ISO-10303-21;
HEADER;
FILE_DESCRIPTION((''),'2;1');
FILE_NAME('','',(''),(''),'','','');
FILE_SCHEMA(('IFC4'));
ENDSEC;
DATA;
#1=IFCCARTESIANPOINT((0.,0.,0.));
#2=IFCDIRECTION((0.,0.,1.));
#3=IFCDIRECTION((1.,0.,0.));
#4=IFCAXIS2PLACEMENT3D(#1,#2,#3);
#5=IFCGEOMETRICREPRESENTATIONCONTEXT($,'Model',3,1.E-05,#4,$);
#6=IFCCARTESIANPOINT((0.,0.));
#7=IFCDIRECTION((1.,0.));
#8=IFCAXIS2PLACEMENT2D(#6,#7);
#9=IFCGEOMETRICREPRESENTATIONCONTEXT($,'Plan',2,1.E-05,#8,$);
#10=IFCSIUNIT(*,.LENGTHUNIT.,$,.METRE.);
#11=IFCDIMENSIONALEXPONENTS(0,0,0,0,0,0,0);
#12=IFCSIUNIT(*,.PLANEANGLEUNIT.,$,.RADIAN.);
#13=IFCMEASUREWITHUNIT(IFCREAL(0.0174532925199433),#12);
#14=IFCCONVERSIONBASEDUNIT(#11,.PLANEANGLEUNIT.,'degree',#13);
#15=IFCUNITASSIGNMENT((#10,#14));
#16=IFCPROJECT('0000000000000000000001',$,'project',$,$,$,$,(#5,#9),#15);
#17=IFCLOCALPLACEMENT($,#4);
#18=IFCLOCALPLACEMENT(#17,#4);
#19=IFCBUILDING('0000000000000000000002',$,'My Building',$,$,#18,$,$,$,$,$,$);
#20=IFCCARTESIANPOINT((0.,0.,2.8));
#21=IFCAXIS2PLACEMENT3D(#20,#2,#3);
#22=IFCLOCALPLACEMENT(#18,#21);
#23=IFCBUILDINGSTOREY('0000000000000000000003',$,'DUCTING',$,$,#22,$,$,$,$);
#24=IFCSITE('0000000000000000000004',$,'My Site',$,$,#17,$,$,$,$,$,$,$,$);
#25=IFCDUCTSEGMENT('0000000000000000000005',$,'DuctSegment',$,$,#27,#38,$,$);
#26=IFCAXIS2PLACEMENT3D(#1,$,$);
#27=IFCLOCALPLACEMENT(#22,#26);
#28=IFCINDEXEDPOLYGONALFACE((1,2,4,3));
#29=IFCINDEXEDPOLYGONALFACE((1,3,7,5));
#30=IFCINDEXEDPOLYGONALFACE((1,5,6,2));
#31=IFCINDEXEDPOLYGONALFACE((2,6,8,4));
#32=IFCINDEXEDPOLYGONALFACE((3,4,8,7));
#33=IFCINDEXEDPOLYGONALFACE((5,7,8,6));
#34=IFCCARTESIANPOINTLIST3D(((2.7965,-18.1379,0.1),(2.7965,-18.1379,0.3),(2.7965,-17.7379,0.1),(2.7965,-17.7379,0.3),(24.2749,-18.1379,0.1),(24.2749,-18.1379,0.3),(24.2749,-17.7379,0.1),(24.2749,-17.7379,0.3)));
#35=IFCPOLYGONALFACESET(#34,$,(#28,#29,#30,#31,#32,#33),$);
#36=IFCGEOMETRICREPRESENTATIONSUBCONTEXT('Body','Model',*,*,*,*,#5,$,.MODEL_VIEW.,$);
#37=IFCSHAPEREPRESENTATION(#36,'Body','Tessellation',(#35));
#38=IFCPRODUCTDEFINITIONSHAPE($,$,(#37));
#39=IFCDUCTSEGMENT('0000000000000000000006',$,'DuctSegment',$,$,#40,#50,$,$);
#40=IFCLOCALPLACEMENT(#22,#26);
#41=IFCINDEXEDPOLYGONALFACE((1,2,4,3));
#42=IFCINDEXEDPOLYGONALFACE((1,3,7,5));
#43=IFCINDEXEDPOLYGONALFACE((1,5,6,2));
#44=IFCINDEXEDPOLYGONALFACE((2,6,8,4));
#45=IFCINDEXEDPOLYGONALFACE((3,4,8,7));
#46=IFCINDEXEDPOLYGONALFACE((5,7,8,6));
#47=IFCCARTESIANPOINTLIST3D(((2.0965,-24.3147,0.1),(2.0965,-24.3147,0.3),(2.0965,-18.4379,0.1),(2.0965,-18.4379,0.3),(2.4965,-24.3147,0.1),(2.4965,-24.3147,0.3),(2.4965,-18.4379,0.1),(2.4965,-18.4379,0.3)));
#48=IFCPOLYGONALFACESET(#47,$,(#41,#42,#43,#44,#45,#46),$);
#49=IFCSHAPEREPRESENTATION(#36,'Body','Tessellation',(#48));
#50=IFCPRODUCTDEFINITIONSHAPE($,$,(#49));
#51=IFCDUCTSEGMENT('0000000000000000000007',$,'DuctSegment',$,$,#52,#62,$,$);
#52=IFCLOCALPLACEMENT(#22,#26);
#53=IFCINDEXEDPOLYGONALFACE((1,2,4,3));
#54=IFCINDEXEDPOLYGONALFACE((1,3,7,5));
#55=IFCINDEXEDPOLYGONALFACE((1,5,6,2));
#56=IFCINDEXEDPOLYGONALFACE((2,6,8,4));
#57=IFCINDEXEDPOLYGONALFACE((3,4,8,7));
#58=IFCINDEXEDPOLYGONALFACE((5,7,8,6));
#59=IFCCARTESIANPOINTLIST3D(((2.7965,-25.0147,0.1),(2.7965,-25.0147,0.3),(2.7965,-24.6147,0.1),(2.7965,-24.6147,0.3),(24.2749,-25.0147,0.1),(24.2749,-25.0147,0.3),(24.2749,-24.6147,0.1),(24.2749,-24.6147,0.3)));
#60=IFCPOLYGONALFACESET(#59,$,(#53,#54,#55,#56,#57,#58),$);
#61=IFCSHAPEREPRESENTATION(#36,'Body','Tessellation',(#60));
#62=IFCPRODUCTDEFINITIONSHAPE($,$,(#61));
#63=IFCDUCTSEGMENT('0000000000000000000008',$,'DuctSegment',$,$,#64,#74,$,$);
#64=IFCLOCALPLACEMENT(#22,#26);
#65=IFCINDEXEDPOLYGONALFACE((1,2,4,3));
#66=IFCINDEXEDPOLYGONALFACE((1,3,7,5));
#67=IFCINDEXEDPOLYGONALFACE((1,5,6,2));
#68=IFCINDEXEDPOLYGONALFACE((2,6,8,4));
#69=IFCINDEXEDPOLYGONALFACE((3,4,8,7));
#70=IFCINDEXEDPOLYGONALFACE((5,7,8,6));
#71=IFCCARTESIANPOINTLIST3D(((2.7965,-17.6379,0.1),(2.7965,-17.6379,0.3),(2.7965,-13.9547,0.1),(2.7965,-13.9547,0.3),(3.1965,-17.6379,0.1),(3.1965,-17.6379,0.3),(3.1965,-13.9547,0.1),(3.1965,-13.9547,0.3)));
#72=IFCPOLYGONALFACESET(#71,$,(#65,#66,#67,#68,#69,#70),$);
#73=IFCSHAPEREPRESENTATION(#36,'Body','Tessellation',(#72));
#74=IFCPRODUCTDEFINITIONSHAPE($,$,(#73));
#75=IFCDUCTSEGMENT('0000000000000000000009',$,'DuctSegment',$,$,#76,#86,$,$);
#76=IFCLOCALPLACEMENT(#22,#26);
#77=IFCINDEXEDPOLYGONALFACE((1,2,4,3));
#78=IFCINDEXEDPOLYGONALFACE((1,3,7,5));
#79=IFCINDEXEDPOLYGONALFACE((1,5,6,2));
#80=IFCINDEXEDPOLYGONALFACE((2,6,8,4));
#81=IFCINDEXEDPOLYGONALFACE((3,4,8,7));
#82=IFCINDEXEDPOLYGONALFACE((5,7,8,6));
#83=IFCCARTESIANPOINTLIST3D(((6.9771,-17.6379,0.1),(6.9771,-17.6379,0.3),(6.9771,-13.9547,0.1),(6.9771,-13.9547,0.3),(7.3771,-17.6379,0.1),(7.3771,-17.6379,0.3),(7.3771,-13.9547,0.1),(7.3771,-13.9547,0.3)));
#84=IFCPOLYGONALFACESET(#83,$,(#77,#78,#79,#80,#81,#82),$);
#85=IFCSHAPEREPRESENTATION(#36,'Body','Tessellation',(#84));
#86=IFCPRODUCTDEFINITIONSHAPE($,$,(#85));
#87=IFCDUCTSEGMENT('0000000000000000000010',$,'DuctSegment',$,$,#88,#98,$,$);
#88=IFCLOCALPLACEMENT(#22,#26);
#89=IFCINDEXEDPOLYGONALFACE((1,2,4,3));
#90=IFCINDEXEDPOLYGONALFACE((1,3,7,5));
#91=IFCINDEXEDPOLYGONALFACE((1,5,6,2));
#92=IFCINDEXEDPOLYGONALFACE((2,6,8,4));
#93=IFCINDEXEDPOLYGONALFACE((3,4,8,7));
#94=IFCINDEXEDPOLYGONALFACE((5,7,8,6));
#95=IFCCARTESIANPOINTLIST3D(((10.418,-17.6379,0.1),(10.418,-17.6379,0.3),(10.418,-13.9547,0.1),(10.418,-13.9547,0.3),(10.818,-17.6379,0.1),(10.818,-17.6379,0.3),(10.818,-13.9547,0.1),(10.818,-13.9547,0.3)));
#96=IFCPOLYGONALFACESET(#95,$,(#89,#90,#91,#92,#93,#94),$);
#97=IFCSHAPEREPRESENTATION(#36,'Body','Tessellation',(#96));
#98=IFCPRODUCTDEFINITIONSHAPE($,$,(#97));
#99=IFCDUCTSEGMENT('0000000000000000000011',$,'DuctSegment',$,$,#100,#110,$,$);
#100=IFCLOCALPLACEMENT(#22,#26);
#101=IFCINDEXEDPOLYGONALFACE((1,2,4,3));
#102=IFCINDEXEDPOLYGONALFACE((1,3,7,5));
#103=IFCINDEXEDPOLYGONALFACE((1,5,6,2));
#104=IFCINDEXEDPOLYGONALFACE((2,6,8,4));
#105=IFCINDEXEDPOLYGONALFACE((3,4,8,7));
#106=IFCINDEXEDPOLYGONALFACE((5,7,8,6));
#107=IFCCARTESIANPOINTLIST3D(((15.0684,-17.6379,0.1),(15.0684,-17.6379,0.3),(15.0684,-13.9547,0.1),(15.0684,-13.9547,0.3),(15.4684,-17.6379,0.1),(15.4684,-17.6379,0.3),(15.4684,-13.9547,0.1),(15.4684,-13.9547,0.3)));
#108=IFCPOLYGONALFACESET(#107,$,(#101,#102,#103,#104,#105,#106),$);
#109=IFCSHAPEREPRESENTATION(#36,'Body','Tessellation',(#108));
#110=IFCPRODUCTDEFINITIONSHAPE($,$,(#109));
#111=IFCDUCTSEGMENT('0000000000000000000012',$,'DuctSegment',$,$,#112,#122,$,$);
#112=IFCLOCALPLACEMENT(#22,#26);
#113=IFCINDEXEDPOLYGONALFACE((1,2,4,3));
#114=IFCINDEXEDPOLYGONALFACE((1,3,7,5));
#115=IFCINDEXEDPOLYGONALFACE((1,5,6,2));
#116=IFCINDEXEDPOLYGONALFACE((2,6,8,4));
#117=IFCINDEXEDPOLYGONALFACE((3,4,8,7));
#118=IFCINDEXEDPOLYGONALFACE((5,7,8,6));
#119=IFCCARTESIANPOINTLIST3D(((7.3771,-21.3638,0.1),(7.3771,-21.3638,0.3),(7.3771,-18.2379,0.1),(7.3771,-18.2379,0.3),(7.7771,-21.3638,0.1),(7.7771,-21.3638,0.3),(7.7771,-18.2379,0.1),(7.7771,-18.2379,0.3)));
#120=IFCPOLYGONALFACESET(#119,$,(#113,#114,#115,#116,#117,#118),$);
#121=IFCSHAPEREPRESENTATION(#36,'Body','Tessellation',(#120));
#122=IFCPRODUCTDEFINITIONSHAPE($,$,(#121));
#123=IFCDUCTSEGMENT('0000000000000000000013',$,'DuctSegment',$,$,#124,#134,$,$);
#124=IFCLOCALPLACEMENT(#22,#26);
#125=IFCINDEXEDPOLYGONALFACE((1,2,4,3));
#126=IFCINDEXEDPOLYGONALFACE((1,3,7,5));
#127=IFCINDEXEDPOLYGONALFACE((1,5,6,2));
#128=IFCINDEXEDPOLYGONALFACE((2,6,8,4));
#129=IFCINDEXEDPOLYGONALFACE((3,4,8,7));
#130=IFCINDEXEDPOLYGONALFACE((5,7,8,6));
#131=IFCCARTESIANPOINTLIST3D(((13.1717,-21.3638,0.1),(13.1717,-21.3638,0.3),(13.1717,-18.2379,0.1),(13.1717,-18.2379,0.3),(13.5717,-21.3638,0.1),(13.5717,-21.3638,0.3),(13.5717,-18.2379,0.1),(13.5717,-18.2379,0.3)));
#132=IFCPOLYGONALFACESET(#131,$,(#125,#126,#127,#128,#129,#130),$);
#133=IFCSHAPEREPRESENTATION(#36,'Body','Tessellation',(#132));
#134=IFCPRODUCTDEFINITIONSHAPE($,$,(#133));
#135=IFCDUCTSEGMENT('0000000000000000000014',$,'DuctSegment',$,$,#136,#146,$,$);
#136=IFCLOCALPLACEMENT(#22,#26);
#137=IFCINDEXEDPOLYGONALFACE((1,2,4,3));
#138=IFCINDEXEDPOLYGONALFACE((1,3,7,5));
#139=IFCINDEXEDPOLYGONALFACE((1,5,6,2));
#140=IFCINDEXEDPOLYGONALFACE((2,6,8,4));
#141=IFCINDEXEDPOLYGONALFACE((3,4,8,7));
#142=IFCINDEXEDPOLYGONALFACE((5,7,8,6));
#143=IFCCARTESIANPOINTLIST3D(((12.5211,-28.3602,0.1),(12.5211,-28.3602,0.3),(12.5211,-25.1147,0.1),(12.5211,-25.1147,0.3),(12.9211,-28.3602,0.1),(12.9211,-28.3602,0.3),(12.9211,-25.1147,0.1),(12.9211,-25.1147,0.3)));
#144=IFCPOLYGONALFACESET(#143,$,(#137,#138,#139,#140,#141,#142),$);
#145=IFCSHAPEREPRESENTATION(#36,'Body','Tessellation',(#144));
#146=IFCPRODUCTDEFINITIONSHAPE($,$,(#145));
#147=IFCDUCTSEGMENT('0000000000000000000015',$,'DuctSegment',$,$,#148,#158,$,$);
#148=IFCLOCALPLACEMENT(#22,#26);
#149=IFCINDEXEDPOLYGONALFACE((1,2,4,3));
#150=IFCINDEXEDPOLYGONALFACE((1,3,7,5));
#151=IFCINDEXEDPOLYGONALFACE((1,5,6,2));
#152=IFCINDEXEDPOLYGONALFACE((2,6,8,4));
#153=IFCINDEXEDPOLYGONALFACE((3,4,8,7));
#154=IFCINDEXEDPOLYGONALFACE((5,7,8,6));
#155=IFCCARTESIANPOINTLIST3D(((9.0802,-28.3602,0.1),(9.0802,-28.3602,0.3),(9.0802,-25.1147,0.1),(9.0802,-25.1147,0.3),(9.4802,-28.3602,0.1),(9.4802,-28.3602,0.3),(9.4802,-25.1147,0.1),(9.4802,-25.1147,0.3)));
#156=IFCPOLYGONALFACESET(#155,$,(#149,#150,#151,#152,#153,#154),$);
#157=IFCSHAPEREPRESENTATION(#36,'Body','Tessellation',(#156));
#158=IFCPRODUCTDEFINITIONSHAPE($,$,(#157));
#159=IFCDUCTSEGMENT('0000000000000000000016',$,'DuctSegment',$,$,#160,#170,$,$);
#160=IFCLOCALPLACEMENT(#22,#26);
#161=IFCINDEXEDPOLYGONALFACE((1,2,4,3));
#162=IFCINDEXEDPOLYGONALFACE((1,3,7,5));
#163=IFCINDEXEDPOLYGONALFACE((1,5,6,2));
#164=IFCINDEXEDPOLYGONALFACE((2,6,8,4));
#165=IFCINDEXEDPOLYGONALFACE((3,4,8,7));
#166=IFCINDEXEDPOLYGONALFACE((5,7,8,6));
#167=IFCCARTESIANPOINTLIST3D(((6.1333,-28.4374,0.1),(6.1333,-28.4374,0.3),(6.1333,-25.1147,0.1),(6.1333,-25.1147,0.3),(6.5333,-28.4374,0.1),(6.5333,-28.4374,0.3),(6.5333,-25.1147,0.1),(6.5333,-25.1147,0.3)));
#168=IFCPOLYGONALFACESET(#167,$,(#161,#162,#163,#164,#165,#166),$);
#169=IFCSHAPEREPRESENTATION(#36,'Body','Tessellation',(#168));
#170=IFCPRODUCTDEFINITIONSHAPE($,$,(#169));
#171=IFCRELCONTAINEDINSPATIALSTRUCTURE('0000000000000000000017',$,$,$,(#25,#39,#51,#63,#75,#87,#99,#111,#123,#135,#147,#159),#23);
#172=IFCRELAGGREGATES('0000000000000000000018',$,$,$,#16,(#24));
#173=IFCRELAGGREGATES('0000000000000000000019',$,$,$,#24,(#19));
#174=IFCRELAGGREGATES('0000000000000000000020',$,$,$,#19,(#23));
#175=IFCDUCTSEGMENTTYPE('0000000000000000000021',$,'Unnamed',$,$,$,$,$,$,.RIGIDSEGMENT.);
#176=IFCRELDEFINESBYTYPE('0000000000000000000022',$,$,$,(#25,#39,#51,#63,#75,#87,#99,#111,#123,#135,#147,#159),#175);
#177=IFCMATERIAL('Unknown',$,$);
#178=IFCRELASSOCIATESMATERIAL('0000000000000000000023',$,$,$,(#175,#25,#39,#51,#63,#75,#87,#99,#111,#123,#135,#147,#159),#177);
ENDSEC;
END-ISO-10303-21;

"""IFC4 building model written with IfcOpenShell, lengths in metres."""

from ifc_helpers import new_model, entity, si_unit, converted_unit, frame, origin_with_axes, origin_2d_with_axis, place, context, subcontext, project, spatial, rectangle, extrude, material, material_profile, profile_set, profile_usage, type_object, element, save


model = new_model("IFC4")

# Units and contexts
model_context = context("Model", 3, precision=1e-05, world=origin_with_axes())
plan_context = context("Plan", 2, precision=1e-05, world=origin_2d_with_axis())
body_context = subcontext(model_context, "Body", "Model", "MODEL_VIEW")
ifc_project = project(units=[si_unit("LENGTHUNIT", "METRE"), converted_unit("PLANEANGLEUNIT", "degree", entity("IfcReal", 0.0174532925199433), si_unit("PLANEANGLEUNIT", "RADIAN"), dimensions=[0, 0, 0, 0, 0, 0, 0])], contexts=[model_context, plan_context])

# Site, building, storey
site_placement = place(None, origin_with_axes())
site = spatial("IfcSite", under=ifc_project, at=site_placement, Name="My Site")
building_placement = place(site_placement, origin_with_axes())
building = spatial("IfcBuilding", under=site, at=building_placement, Name="My Building")
storey_placement = place(building_placement, frame((0.0, 0.0, 2.8), z_axis=(0.0, 0.0, 1.0), x_axis=(1.0, 0.0, 0.0)))
storey = spatial("IfcBuildingStorey", under=building, at=storey_placement, Name="DUCTING")

# Duct segments
ifc_material = material(Name="Unknown")
ifc_material_profile_1 = material_profile(ifc_material, rectangle(XDim=0.4, YDim=0.2))
ifc_profile_set_1 = profile_set([ifc_material_profile_1])
ifc_profile_usage_1 = profile_usage(ifc_profile_set_1, cardinal=5)
duct_segment_type = type_object("IfcDuctSegmentType", Name="Unnamed", PredefinedType="RIGIDSEGMENT", material=ifc_profile_set_1)
duct_segment_1_placement = place(storey_placement, frame((2.7965, -17.9379, 0.2), z_axis=(1.0, 0.0, 0.0), x_axis=(0.0, 1.0, 0.0)))
element("IfcDuctSegment", 1, at=duct_segment_1_placement, inside=storey, type_object=duct_segment_type, material=ifc_profile_usage_1, Name="DuctSegment", context=body_context, shape_type="SweptSolid", body=[
    extrude(rectangle(XDim=0.4, YDim=0.2), origin_with_axes(), (0.0, 0.0, 1.0), 21.4785),
])
ifc_profile_usage_2 = profile_usage(ifc_profile_set_1, cardinal=5)
duct_segment_2_placement = place(storey_placement, frame((2.2965, -24.3147, 0.2), z_axis=(0.0, 1.0, 0.0), x_axis=(-1.0, 0.0, 0.0)))
element("IfcDuctSegment", 2, at=duct_segment_2_placement, inside=storey, type_object=duct_segment_type, material=ifc_profile_usage_2, Name="DuctSegment", context=body_context, shape_type="SweptSolid", body=[
    extrude(rectangle(XDim=0.4, YDim=0.2), origin_with_axes(), (0.0, 0.0, 1.0), 5.8768),
])
ifc_profile_usage_3 = profile_usage(ifc_profile_set_1, cardinal=5)
duct_segment_3_placement = place(storey_placement, frame((2.7965, -24.8147, 0.2), z_axis=(1.0, 0.0, 0.0), x_axis=(0.0, 1.0, 0.0)))
element("IfcDuctSegment", 3, at=duct_segment_3_placement, inside=storey, type_object=duct_segment_type, material=ifc_profile_usage_3, Name="DuctSegment", context=body_context, shape_type="SweptSolid", body=[
    extrude(rectangle(XDim=0.4, YDim=0.2), origin_with_axes(), (0.0, 0.0, 1.0), 21.4785),
])
ifc_profile_usage_4 = profile_usage(ifc_profile_set_1, cardinal=5)
duct_segment_4_placement = place(storey_placement, frame((2.9965, -17.6379, 0.2), z_axis=(0.0, 1.0, 0.0), x_axis=(-1.0, 0.0, 0.0)))
element("IfcDuctSegment", 4, at=duct_segment_4_placement, inside=storey, type_object=duct_segment_type, material=ifc_profile_usage_4, Name="DuctSegment", context=body_context, shape_type="SweptSolid", body=[
    extrude(rectangle(XDim=0.4, YDim=0.2), origin_with_axes(), (0.0, 0.0, 1.0), 3.6833),
])
ifc_profile_usage_5 = profile_usage(ifc_profile_set_1, cardinal=5)
duct_segment_5_placement = place(storey_placement, frame((7.1771, -17.6379, 0.2), z_axis=(0.0, 1.0, 0.0), x_axis=(-1.0, 0.0, 0.0)))
element("IfcDuctSegment", 5, at=duct_segment_5_placement, inside=storey, type_object=duct_segment_type, material=ifc_profile_usage_5, Name="DuctSegment", context=body_context, shape_type="SweptSolid", body=[
    extrude(rectangle(XDim=0.4, YDim=0.2), origin_with_axes(), (0.0, 0.0, 1.0), 3.6833),
])
ifc_profile_usage_6 = profile_usage(ifc_profile_set_1, cardinal=5)
duct_segment_6_placement = place(storey_placement, frame((10.618, -17.6379, 0.2), z_axis=(0.0, 1.0, 0.0), x_axis=(-1.0, 0.0, 0.0)))
element("IfcDuctSegment", 6, at=duct_segment_6_placement, inside=storey, type_object=duct_segment_type, material=ifc_profile_usage_6, Name="DuctSegment", context=body_context, shape_type="SweptSolid", body=[
    extrude(rectangle(XDim=0.4, YDim=0.2), origin_with_axes(), (0.0, 0.0, 1.0), 3.6833),
])
ifc_profile_usage_7 = profile_usage(ifc_profile_set_1, cardinal=5)
duct_segment_7_placement = place(storey_placement, frame((15.2684, -17.6379, 0.2), z_axis=(0.0, 1.0, 0.0), x_axis=(-1.0, 0.0, 0.0)))
element("IfcDuctSegment", 7, at=duct_segment_7_placement, inside=storey, type_object=duct_segment_type, material=ifc_profile_usage_7, Name="DuctSegment", context=body_context, shape_type="SweptSolid", body=[
    extrude(rectangle(XDim=0.4, YDim=0.2), origin_with_axes(), (0.0, 0.0, 1.0), 3.6833),
])
ifc_profile_usage_8 = profile_usage(ifc_profile_set_1, cardinal=5)
duct_segment_8_placement = place(storey_placement, frame((7.5771, -18.2379, 0.2), z_axis=(0.0, -1.0, 0.0), x_axis=(1.0, 0.0, 0.0)))
element("IfcDuctSegment", 8, at=duct_segment_8_placement, inside=storey, type_object=duct_segment_type, material=ifc_profile_usage_8, Name="DuctSegment", context=body_context, shape_type="SweptSolid", body=[
    extrude(rectangle(XDim=0.4, YDim=0.2), origin_with_axes(), (0.0, 0.0, 1.0), 3.1259),
])
ifc_profile_usage_9 = profile_usage(ifc_profile_set_1, cardinal=5)
duct_segment_9_placement = place(storey_placement, frame((13.3717, -18.2379, 0.2), z_axis=(0.0, -1.0, 0.0), x_axis=(1.0, 0.0, 0.0)))
element("IfcDuctSegment", 9, at=duct_segment_9_placement, inside=storey, type_object=duct_segment_type, material=ifc_profile_usage_9, Name="DuctSegment", context=body_context, shape_type="SweptSolid", body=[
    extrude(rectangle(XDim=0.4, YDim=0.2), origin_with_axes(), (0.0, 0.0, 1.0), 3.1259),
])
ifc_profile_usage_10 = profile_usage(ifc_profile_set_1, cardinal=5)
duct_segment_10_placement = place(storey_placement, frame((12.7211, -25.1147, 0.2), z_axis=(0.0, -1.0, 0.0), x_axis=(1.0, 0.0, 0.0)))
element("IfcDuctSegment", 10, at=duct_segment_10_placement, inside=storey, type_object=duct_segment_type, material=ifc_profile_usage_10, Name="DuctSegment", context=body_context, shape_type="SweptSolid", body=[
    extrude(rectangle(XDim=0.4, YDim=0.2), origin_with_axes(), (0.0, 0.0, 1.0), 3.2455),
])
ifc_profile_usage_11 = profile_usage(ifc_profile_set_1, cardinal=5)
duct_segment_11_placement = place(storey_placement, frame((9.2802, -25.1147, 0.2), z_axis=(0.0, -1.0, 0.0), x_axis=(1.0, 0.0, 0.0)))
element("IfcDuctSegment", 11, at=duct_segment_11_placement, inside=storey, type_object=duct_segment_type, material=ifc_profile_usage_11, Name="DuctSegment", context=body_context, shape_type="SweptSolid", body=[
    extrude(rectangle(XDim=0.4, YDim=0.2), origin_with_axes(), (0.0, 0.0, 1.0), 3.2455),
])
ifc_profile_usage_12 = profile_usage(ifc_profile_set_1, cardinal=5)
duct_segment_12_placement = place(storey_placement, frame((6.3333, -25.1147, 0.2), z_axis=(0.0, -1.0, 0.0), x_axis=(1.0, 0.0, 0.0)))
element("IfcDuctSegment", 12, at=duct_segment_12_placement, inside=storey, type_object=duct_segment_type, material=ifc_profile_usage_12, Name="DuctSegment", context=body_context, shape_type="SweptSolid", body=[
    extrude(rectangle(XDim=0.4, YDim=0.2), origin_with_axes(), (0.0, 0.0, 1.0), 3.3227),
])

save(model, "model.ifc")
